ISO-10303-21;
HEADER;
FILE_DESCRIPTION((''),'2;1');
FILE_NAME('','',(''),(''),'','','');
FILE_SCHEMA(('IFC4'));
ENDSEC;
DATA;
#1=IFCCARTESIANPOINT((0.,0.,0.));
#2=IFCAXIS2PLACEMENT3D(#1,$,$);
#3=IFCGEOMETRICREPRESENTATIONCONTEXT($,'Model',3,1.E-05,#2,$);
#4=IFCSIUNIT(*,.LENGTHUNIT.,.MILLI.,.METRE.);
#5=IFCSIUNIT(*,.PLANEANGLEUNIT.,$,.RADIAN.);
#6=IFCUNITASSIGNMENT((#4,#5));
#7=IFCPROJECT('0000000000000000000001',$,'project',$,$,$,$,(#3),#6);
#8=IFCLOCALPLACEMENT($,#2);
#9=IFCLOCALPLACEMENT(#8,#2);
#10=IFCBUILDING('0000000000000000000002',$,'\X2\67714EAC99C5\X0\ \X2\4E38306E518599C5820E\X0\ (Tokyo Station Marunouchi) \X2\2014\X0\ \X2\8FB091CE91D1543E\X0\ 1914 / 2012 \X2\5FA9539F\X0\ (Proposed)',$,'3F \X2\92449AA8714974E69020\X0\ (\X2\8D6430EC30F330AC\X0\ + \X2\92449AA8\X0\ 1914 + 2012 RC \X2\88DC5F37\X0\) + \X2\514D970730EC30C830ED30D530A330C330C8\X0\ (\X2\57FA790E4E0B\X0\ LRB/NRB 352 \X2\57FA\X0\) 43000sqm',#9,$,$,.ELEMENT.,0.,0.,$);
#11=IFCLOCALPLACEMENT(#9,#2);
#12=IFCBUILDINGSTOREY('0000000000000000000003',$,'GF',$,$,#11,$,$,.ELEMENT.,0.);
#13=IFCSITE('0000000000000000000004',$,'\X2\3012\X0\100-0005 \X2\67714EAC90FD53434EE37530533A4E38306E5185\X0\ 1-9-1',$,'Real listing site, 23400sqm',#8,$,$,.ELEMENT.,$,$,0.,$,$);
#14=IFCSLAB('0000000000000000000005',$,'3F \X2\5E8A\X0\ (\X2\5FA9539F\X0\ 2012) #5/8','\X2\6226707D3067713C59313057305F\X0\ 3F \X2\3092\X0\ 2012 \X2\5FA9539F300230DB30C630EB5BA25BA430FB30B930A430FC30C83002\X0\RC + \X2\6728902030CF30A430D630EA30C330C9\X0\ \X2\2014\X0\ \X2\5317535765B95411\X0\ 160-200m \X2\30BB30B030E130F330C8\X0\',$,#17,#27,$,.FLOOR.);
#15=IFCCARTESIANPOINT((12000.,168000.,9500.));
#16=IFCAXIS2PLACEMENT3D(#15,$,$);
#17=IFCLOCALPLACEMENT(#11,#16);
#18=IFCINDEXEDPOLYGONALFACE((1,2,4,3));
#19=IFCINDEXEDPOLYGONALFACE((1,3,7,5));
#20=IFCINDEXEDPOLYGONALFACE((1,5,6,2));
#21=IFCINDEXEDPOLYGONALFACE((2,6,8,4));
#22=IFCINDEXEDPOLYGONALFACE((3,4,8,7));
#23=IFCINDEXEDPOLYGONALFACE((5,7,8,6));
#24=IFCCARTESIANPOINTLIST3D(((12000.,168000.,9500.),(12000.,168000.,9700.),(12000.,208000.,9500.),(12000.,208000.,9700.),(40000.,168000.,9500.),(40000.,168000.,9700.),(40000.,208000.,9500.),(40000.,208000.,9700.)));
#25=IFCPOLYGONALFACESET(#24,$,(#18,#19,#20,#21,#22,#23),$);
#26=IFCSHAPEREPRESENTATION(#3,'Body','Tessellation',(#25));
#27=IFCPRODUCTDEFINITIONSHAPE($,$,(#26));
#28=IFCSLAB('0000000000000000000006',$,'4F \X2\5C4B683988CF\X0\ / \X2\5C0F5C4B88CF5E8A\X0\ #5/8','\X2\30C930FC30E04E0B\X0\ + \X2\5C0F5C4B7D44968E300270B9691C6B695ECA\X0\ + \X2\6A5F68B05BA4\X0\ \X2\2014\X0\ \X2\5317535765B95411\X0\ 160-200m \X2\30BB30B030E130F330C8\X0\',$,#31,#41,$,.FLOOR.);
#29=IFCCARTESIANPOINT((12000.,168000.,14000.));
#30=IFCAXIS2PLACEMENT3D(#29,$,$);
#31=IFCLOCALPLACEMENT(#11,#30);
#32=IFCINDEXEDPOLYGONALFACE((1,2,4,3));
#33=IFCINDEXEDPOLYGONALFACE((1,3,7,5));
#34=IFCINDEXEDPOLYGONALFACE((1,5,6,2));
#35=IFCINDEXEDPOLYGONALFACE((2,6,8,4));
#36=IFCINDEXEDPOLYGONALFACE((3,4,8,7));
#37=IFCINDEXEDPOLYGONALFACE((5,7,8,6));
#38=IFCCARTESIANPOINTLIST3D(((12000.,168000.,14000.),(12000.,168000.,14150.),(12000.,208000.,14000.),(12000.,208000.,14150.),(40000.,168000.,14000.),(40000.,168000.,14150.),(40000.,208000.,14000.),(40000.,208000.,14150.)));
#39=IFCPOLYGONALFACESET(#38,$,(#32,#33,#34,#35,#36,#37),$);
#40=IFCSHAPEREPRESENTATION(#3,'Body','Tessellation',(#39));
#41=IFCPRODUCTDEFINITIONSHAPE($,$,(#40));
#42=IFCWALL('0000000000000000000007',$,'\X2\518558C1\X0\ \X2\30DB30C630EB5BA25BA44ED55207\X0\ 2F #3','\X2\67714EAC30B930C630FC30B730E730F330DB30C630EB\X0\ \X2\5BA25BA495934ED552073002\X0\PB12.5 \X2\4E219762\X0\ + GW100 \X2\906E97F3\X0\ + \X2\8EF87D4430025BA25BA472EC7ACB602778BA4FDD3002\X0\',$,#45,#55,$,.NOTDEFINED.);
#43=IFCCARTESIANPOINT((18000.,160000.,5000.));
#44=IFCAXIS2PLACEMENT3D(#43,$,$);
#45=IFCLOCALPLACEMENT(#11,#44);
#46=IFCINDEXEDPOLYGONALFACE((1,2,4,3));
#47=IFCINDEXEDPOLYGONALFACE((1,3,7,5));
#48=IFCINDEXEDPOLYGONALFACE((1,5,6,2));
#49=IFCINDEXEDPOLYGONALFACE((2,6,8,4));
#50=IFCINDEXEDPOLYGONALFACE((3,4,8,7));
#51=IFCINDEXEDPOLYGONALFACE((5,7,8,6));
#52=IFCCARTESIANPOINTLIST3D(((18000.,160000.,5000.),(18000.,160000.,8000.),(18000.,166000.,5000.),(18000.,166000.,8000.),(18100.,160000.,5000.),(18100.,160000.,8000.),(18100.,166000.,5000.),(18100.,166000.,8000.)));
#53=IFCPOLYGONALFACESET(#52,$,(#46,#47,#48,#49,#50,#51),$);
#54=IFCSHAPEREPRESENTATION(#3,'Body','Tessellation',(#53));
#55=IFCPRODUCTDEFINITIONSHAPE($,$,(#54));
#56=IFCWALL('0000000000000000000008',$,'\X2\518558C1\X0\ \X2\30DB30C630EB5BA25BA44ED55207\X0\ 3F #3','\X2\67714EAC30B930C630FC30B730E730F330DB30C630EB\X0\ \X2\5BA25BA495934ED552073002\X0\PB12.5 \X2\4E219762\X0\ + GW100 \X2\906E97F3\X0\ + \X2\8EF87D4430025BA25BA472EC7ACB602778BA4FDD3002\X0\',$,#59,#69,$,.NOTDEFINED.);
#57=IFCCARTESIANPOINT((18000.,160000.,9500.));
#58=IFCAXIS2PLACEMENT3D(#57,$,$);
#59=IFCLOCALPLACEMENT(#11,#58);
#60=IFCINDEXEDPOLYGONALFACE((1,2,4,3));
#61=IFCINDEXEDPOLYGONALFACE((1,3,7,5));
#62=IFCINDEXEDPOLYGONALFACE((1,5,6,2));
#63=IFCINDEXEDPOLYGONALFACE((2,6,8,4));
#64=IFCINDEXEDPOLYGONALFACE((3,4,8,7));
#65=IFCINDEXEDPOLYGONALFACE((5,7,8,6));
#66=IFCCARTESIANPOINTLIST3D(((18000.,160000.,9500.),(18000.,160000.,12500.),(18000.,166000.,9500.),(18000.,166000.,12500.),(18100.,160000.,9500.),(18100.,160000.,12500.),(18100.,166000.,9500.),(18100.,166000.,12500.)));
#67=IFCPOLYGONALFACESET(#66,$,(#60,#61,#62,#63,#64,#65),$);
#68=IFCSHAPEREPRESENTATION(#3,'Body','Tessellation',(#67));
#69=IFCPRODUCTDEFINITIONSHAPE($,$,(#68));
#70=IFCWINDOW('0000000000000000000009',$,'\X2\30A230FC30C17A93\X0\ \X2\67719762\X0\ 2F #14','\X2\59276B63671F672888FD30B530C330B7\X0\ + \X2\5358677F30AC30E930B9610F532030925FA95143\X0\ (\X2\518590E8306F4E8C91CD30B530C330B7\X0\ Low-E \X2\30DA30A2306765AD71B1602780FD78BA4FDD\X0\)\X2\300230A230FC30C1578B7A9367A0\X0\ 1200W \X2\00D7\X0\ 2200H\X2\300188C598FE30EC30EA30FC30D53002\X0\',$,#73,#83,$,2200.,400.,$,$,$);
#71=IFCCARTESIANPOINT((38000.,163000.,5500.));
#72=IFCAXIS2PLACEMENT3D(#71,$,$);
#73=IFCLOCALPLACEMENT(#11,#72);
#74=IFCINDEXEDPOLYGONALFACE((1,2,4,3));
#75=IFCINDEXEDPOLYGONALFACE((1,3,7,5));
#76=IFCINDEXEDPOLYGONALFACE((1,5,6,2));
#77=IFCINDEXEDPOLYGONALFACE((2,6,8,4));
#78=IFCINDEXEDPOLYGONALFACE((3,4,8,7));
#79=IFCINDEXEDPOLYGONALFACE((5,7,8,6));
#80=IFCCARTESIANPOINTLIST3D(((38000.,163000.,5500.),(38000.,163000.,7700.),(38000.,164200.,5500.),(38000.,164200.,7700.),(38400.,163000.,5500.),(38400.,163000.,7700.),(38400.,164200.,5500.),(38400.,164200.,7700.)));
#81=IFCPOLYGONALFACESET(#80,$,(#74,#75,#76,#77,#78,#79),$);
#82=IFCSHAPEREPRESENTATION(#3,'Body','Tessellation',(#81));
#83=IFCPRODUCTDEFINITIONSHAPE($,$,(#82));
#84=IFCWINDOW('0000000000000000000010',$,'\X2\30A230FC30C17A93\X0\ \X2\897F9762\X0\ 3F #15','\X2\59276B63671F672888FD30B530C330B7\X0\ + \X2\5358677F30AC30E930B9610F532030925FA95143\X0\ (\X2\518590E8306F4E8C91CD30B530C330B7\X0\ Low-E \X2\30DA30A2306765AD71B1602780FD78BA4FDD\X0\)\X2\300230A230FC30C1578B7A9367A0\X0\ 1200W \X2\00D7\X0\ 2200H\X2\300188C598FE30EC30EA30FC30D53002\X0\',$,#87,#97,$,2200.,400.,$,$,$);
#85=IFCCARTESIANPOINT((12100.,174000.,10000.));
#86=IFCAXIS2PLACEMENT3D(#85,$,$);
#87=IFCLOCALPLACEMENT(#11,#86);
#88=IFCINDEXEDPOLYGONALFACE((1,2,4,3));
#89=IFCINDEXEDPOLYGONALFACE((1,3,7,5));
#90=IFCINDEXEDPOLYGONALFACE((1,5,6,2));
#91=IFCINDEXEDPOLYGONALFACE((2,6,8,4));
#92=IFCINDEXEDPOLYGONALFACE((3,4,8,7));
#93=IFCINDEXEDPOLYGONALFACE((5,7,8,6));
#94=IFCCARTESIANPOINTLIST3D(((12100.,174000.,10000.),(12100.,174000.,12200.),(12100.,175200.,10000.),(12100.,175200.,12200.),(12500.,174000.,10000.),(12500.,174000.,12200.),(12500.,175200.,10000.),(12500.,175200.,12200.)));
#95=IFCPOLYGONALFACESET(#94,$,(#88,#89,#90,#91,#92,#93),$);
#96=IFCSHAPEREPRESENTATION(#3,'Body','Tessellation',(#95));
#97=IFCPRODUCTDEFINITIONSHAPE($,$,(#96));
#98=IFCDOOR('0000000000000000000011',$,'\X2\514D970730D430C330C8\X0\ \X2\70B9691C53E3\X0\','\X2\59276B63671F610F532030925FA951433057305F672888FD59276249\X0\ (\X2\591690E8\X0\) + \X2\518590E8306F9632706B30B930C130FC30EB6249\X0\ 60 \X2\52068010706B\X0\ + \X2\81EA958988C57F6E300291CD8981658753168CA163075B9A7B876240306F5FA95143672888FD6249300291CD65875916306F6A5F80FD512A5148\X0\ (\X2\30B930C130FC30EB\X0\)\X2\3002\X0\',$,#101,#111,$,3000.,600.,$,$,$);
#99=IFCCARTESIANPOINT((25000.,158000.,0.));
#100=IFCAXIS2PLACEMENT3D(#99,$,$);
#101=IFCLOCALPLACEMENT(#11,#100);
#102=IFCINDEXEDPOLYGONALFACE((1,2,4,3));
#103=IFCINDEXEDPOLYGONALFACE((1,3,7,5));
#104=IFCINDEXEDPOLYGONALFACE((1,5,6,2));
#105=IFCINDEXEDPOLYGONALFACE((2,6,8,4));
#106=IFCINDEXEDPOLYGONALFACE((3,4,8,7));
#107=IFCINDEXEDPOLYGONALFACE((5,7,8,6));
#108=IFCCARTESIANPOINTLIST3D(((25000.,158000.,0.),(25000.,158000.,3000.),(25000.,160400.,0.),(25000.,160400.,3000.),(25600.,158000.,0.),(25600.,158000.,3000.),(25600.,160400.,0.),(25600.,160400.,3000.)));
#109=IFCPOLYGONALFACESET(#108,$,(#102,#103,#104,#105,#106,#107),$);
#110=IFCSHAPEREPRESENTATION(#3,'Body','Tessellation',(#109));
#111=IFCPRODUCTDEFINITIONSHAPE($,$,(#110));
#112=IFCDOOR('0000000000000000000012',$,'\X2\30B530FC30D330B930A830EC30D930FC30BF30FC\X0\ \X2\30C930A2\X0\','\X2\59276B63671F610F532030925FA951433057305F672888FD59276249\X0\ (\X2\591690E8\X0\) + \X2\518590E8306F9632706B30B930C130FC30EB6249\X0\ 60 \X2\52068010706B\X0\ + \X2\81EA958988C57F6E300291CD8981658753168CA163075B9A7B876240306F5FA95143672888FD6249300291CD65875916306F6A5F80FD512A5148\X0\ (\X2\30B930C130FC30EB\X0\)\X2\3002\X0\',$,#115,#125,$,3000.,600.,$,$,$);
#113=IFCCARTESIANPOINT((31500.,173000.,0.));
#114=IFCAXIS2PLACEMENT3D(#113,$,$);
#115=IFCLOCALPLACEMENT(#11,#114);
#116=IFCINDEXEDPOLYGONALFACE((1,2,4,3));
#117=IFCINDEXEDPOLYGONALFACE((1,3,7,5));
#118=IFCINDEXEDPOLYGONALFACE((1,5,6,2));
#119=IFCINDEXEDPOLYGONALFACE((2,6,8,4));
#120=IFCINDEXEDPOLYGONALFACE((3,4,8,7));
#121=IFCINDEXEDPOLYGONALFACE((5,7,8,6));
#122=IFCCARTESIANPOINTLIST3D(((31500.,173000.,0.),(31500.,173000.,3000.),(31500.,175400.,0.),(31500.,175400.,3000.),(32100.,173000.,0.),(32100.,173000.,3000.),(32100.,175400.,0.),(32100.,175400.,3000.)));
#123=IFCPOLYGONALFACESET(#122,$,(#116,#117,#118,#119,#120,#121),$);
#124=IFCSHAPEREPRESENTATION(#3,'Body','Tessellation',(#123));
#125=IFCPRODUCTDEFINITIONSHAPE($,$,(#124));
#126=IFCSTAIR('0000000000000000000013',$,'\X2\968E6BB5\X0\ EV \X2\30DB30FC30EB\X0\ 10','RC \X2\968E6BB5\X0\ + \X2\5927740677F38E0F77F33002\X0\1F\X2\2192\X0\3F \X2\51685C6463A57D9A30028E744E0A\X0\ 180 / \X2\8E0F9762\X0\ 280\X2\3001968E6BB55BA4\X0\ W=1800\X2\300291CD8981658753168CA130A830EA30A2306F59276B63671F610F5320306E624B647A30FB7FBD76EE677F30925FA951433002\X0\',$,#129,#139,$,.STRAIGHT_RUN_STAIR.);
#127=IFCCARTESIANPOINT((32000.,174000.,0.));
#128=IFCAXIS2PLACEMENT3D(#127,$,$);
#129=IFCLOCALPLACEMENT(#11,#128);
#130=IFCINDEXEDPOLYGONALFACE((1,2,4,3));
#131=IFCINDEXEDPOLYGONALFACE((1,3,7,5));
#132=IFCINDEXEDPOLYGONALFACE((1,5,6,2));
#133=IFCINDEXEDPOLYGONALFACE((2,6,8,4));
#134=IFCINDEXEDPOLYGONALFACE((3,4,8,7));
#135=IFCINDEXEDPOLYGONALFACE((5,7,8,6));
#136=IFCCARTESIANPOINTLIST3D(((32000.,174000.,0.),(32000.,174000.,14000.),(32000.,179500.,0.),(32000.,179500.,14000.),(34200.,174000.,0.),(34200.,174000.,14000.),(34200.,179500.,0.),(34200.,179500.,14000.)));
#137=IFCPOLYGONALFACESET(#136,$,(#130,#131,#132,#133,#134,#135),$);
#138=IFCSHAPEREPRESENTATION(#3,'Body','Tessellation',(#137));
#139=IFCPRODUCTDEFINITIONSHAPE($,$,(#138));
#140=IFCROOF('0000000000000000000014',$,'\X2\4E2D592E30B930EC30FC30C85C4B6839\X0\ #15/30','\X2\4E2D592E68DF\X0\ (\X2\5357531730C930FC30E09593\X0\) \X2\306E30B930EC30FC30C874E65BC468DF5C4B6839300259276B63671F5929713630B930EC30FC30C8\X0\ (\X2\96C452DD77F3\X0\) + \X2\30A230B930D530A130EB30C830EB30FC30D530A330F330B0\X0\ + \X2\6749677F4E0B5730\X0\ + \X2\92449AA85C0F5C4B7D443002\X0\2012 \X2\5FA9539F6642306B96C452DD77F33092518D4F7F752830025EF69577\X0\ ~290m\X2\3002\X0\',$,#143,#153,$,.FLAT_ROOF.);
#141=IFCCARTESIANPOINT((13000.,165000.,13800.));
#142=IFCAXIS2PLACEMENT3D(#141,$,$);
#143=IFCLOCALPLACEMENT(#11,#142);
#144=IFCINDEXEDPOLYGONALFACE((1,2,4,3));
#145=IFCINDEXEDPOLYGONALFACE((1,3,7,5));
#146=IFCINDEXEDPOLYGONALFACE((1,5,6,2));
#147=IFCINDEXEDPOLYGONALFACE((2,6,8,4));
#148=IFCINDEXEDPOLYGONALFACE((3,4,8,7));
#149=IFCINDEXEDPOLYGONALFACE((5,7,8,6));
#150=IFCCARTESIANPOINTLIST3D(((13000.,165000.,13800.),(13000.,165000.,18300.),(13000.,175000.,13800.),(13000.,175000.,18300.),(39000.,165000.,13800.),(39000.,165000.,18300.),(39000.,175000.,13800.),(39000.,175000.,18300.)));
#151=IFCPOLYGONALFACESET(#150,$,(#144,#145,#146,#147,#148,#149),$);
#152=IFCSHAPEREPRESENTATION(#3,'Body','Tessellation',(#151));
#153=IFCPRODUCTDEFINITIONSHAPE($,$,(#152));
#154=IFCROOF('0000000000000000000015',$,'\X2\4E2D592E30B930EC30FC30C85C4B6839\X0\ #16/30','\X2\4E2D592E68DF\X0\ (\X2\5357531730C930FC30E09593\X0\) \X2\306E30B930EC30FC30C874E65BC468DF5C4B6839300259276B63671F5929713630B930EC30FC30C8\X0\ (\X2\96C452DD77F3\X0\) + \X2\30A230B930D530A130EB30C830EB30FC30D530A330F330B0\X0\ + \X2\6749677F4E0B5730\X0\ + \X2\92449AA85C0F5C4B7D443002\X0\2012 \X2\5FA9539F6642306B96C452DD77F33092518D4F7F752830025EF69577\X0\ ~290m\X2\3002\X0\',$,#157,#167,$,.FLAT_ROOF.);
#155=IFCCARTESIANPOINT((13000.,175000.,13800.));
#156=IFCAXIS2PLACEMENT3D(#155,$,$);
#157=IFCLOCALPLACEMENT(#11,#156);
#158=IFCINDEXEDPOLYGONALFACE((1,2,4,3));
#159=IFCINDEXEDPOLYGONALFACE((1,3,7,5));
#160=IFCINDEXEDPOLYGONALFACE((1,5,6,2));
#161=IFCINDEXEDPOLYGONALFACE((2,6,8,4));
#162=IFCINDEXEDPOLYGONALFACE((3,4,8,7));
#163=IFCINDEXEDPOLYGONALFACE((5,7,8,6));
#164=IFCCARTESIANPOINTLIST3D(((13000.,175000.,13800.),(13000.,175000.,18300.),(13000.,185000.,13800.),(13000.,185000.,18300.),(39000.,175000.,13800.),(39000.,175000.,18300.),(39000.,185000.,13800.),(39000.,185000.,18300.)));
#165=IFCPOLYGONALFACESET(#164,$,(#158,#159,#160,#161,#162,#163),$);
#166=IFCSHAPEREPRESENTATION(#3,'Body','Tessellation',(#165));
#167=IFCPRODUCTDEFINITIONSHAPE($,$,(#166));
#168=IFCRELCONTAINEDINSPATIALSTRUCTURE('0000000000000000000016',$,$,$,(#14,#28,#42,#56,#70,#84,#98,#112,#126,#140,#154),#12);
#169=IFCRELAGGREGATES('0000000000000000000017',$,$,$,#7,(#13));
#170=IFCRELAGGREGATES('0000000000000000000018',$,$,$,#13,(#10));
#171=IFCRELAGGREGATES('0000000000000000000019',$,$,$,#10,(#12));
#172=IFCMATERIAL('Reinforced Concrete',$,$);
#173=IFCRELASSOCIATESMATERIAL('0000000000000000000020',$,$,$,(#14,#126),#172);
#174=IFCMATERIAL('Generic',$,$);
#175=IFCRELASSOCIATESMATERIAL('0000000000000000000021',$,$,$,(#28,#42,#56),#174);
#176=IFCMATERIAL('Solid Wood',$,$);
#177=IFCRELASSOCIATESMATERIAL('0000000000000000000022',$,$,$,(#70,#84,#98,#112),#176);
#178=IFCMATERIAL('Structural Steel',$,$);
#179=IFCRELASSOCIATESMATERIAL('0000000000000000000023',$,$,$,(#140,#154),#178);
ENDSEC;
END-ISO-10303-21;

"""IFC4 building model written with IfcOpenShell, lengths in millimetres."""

from ifc_helpers import new_model, si_unit, frame, frame_2d, origin, place, context, project, spatial, rectangle, extrude, material, element, save


model = new_model("IFC4")

# Units and contexts
model_context = context("Model", 3, precision=1e-05, world=origin())
ifc_project = project(units=[si_unit("LENGTHUNIT", "METRE", prefix="MILLI"), si_unit("PLANEANGLEUNIT", "RADIAN")], contexts=[model_context])

# Site, building, storey
site_placement = place(None, origin())
site = spatial("IfcSite", under=ifc_project, at=site_placement, Name="〒100-0005 東京都千代田区丸の内 1-9-1", ObjectType="Real listing site, 23400sqm", CompositionType="ELEMENT", RefElevation=0.0)
building_placement = place(site_placement, origin())
building = spatial("IfcBuilding", under=site, at=building_placement, Name="東京駅 丸の内駅舎 (Tokyo Station Marunouchi) — 辰野金吾 1914 / 2012 復原 (Proposed)", ObjectType="3F 鉄骨煉瓦造 (赤レンガ + 鉄骨 1914 + 2012 RC 補強) + 免震レトロフィット (基礎下 LRB/NRB 352 基) 43000sqm", CompositionType="ELEMENT", ElevationOfRefHeight=0.0, ElevationOfTerrain=0.0)
storey_placement = place(building_placement, origin())
storey = spatial("IfcBuildingStorey", under=building, at=storey_placement, Name="GF", CompositionType="ELEMENT", Elevation=0.0)

# Shared definitions
ifc_material_1 = material(Name="Reinforced Concrete")

# Shared definitions
ifc_material_2 = material(Name="Structural Steel")

# Slabs
slab_1_placement = place(storey_placement, frame((12000.0, 168000.0, 9500.0)))
element("IfcSlab", 1, at=slab_1_placement, inside=storey, material=ifc_material_1, Name="3F 床 (復原 2012) #5/8", Description="戦災で焼失した 3F を 2012 復原。ホテル客室・スイート。RC + 木造ハイブリッド — 北南方向 160-200m セグメント", PredefinedType="FLOOR", context=model_context, shape_type="SweptSolid", body=[
    extrude(rectangle(XDim=28000.0, YDim=40000.0, at=frame_2d((14000.0, 20000.0))), frame((12000.0, 168000.0, 9500.0)), (0.0, 0.0, 1.0), 200.0),
])
ifc_material_3 = material(Name="Generic")
slab_2_placement = place(storey_placement, frame((12000.0, 168000.0, 14000.0)))
element("IfcSlab", 2, at=slab_2_placement, inside=storey, material=ifc_material_3, Name="4F 屋根裏 / 小屋裏床 #5/8", Description="ドーム下 + 小屋組階。点検歩廊 + 機械室 — 北南方向 160-200m セグメント", PredefinedType="FLOOR", context=model_context, shape_type="SweptSolid", body=[
    extrude(rectangle(XDim=28000.0, YDim=40000.0, at=frame_2d((14000.0, 20000.0))), frame((12000.0, 168000.0, 14000.0)), (0.0, 0.0, 1.0), 150.0),
])

# Walls
wall_1_placement = place(storey_placement, frame((18000.0, 160000.0, 5000.0)))
element("IfcWall", 3, at=wall_1_placement, inside=storey, material=ifc_material_3, Name="内壁 ホテル客室仕切 2F #3", Description="東京ステーションホテル 客室間仕切。PB12.5 両面 + GW100 遮音 + 軸組。客室独立性確保。", PredefinedType="NOTDEFINED", context=model_context, shape_type="SweptSolid", body=[
    extrude(rectangle(XDim=100.0, YDim=6000.0, at=frame_2d((50.0, 3000.0))), frame((18000.0, 160000.0, 5000.0)), (0.0, 0.0, 1.0), 3000.0),
])
wall_2_placement = place(storey_placement, frame((18000.0, 160000.0, 9500.0)))
element("IfcWall", 4, at=wall_2_placement, inside=storey, material=ifc_material_3, Name="内壁 ホテル客室仕切 3F #3", Description="東京ステーションホテル 客室間仕切。PB12.5 両面 + GW100 遮音 + 軸組。客室独立性確保。", PredefinedType="NOTDEFINED", context=model_context, shape_type="SweptSolid", body=[
    extrude(rectangle(XDim=100.0, YDim=6000.0, at=frame_2d((50.0, 3000.0))), frame((18000.0, 160000.0, 9500.0)), (0.0, 0.0, 1.0), 3000.0),
])

# Windows
ifc_material_4 = material(Name="Solid Wood")
window_1_placement = place(storey_placement, frame((38000.0, 163000.0, 5500.0)))
element("IfcWindow", 5, at=window_1_placement, inside=storey, material=ifc_material_4, Name="アーチ窓 東面 2F #14", Description="大正期木製サッシ + 単板ガラス意匠を復元 (内部は二重サッシ Low-E ペアで断熱性能確保)。アーチ型窓枠 1200W × 2200H、装飾レリーフ。", OverallHeight=2200.0, OverallWidth=400.0, context=model_context, shape_type="SweptSolid", body=[
    extrude(rectangle(XDim=400.0, YDim=1200.0, at=frame_2d((200.0, 600.0))), frame((38000.0, 163000.0, 5500.0)), (0.0, 0.0, 1.0), 2200.0),
])
window_2_placement = place(storey_placement, frame((12100.0, 174000.0, 10000.0)))
element("IfcWindow", 6, at=window_2_placement, inside=storey, material=ifc_material_4, Name="アーチ窓 西面 3F #15", Description="大正期木製サッシ + 単板ガラス意匠を復元 (内部は二重サッシ Low-E ペアで断熱性能確保)。アーチ型窓枠 1200W × 2200H、装飾レリーフ。", OverallHeight=2200.0, OverallWidth=400.0, context=model_context, shape_type="SweptSolid", body=[
    extrude(rectangle(XDim=400.0, YDim=1200.0, at=frame_2d((200.0, 600.0))), frame((12100.0, 174000.0, 10000.0)), (0.0, 0.0, 1.0), 2200.0),
])

# Doors
door_1_placement = place(storey_placement, frame((25000.0, 158000.0, 0.0)))
element("IfcDoor", 7, at=door_1_placement, inside=storey, material=ifc_material_4, Name="免震ピット 点検口", Description="大正期意匠を復元した木製大扉 (外部) + 内部は防火スチール扉 60 分耐火 + 自閉装置。重要文化財指定箇所は復元木製扉。重文外は機能優先 (スチール)。", OverallHeight=3000.0, OverallWidth=600.0, context=model_context, shape_type="SweptSolid", body=[
    extrude(rectangle(XDim=600.0, YDim=2400.0, at=frame_2d((300.0, 1200.0))), frame((25000.0, 158000.0, 0.0)), (0.0, 0.0, 1.0), 3000.0),
])
door_2_placement = place(storey_placement, frame((31500.0, 173000.0, 0.0)))
element("IfcDoor", 8, at=door_2_placement, inside=storey, material=ifc_material_4, Name="サービスエレベーター ドア", Description="大正期意匠を復元した木製大扉 (外部) + 内部は防火スチール扉 60 分耐火 + 自閉装置。重要文化財指定箇所は復元木製扉。重文外は機能優先 (スチール)。", OverallHeight=3000.0, OverallWidth=600.0, context=model_context, shape_type="SweptSolid", body=[
    extrude(rectangle(XDim=600.0, YDim=2400.0, at=frame_2d((300.0, 1200.0))), frame((31500.0, 173000.0, 0.0)), (0.0, 0.0, 1.0), 3000.0),
])

# Stair
stair_placement = place(storey_placement, frame((32000.0, 174000.0, 0.0)))
element("IfcStair", 9, at=stair_placement, inside=storey, material=ifc_material_1, Name="階段 EV ホール 10", Description="RC 階段 + 大理石踏石。1F→3F 全層接続。蹴上 180 / 踏面 280、階段室 W=1800。重要文化財エリアは大正期意匠の手摺・羽目板を復元。", PredefinedType="STRAIGHT_RUN_STAIR", context=model_context, shape_type="SweptSolid", body=[
    extrude(rectangle(XDim=2200.0, YDim=5500.0, at=frame_2d((1100.0, 2750.0))), frame((32000.0, 174000.0, 0.0)), (0.0, 0.0, 1.0), 14000.0),
])

# Roofs
roof_1_placement = place(storey_placement, frame((13000.0, 165000.0, 13800.0)))
element("IfcRoof", 10, at=roof_1_placement, inside=storey, material=ifc_material_2, Name="中央スレート屋根 #15/30", Description="中央棟 (南北ドーム間) のスレート瓦寄棟屋根。大正期天然スレート (雄勝石) + アスファルトルーフィング + 杉板下地 + 鉄骨小屋組。2012 復原時に雄勝石を再使用。延長 ~290m。", PredefinedType="FLAT_ROOF", context=model_context, shape_type="SweptSolid", body=[
    extrude(rectangle(XDim=26000.0, YDim=10000.0, at=frame_2d((13000.0, 5000.0))), frame((13000.0, 165000.0, 13800.0)), (0.0, 0.0, 1.0), 4500.0),
])
roof_2_placement = place(storey_placement, frame((13000.0, 175000.0, 13800.0)))
element("IfcRoof", 11, at=roof_2_placement, inside=storey, material=ifc_material_2, Name="中央スレート屋根 #16/30", Description="中央棟 (南北ドーム間) のスレート瓦寄棟屋根。大正期天然スレート (雄勝石) + アスファルトルーフィング + 杉板下地 + 鉄骨小屋組。2012 復原時に雄勝石を再使用。延長 ~290m。", PredefinedType="FLAT_ROOF", context=model_context, shape_type="SweptSolid", body=[
    extrude(rectangle(XDim=26000.0, YDim=10000.0, at=frame_2d((13000.0, 5000.0))), frame((13000.0, 175000.0, 13800.0)), (0.0, 0.0, 1.0), 4500.0),
])

save(model, "model.ifc")
